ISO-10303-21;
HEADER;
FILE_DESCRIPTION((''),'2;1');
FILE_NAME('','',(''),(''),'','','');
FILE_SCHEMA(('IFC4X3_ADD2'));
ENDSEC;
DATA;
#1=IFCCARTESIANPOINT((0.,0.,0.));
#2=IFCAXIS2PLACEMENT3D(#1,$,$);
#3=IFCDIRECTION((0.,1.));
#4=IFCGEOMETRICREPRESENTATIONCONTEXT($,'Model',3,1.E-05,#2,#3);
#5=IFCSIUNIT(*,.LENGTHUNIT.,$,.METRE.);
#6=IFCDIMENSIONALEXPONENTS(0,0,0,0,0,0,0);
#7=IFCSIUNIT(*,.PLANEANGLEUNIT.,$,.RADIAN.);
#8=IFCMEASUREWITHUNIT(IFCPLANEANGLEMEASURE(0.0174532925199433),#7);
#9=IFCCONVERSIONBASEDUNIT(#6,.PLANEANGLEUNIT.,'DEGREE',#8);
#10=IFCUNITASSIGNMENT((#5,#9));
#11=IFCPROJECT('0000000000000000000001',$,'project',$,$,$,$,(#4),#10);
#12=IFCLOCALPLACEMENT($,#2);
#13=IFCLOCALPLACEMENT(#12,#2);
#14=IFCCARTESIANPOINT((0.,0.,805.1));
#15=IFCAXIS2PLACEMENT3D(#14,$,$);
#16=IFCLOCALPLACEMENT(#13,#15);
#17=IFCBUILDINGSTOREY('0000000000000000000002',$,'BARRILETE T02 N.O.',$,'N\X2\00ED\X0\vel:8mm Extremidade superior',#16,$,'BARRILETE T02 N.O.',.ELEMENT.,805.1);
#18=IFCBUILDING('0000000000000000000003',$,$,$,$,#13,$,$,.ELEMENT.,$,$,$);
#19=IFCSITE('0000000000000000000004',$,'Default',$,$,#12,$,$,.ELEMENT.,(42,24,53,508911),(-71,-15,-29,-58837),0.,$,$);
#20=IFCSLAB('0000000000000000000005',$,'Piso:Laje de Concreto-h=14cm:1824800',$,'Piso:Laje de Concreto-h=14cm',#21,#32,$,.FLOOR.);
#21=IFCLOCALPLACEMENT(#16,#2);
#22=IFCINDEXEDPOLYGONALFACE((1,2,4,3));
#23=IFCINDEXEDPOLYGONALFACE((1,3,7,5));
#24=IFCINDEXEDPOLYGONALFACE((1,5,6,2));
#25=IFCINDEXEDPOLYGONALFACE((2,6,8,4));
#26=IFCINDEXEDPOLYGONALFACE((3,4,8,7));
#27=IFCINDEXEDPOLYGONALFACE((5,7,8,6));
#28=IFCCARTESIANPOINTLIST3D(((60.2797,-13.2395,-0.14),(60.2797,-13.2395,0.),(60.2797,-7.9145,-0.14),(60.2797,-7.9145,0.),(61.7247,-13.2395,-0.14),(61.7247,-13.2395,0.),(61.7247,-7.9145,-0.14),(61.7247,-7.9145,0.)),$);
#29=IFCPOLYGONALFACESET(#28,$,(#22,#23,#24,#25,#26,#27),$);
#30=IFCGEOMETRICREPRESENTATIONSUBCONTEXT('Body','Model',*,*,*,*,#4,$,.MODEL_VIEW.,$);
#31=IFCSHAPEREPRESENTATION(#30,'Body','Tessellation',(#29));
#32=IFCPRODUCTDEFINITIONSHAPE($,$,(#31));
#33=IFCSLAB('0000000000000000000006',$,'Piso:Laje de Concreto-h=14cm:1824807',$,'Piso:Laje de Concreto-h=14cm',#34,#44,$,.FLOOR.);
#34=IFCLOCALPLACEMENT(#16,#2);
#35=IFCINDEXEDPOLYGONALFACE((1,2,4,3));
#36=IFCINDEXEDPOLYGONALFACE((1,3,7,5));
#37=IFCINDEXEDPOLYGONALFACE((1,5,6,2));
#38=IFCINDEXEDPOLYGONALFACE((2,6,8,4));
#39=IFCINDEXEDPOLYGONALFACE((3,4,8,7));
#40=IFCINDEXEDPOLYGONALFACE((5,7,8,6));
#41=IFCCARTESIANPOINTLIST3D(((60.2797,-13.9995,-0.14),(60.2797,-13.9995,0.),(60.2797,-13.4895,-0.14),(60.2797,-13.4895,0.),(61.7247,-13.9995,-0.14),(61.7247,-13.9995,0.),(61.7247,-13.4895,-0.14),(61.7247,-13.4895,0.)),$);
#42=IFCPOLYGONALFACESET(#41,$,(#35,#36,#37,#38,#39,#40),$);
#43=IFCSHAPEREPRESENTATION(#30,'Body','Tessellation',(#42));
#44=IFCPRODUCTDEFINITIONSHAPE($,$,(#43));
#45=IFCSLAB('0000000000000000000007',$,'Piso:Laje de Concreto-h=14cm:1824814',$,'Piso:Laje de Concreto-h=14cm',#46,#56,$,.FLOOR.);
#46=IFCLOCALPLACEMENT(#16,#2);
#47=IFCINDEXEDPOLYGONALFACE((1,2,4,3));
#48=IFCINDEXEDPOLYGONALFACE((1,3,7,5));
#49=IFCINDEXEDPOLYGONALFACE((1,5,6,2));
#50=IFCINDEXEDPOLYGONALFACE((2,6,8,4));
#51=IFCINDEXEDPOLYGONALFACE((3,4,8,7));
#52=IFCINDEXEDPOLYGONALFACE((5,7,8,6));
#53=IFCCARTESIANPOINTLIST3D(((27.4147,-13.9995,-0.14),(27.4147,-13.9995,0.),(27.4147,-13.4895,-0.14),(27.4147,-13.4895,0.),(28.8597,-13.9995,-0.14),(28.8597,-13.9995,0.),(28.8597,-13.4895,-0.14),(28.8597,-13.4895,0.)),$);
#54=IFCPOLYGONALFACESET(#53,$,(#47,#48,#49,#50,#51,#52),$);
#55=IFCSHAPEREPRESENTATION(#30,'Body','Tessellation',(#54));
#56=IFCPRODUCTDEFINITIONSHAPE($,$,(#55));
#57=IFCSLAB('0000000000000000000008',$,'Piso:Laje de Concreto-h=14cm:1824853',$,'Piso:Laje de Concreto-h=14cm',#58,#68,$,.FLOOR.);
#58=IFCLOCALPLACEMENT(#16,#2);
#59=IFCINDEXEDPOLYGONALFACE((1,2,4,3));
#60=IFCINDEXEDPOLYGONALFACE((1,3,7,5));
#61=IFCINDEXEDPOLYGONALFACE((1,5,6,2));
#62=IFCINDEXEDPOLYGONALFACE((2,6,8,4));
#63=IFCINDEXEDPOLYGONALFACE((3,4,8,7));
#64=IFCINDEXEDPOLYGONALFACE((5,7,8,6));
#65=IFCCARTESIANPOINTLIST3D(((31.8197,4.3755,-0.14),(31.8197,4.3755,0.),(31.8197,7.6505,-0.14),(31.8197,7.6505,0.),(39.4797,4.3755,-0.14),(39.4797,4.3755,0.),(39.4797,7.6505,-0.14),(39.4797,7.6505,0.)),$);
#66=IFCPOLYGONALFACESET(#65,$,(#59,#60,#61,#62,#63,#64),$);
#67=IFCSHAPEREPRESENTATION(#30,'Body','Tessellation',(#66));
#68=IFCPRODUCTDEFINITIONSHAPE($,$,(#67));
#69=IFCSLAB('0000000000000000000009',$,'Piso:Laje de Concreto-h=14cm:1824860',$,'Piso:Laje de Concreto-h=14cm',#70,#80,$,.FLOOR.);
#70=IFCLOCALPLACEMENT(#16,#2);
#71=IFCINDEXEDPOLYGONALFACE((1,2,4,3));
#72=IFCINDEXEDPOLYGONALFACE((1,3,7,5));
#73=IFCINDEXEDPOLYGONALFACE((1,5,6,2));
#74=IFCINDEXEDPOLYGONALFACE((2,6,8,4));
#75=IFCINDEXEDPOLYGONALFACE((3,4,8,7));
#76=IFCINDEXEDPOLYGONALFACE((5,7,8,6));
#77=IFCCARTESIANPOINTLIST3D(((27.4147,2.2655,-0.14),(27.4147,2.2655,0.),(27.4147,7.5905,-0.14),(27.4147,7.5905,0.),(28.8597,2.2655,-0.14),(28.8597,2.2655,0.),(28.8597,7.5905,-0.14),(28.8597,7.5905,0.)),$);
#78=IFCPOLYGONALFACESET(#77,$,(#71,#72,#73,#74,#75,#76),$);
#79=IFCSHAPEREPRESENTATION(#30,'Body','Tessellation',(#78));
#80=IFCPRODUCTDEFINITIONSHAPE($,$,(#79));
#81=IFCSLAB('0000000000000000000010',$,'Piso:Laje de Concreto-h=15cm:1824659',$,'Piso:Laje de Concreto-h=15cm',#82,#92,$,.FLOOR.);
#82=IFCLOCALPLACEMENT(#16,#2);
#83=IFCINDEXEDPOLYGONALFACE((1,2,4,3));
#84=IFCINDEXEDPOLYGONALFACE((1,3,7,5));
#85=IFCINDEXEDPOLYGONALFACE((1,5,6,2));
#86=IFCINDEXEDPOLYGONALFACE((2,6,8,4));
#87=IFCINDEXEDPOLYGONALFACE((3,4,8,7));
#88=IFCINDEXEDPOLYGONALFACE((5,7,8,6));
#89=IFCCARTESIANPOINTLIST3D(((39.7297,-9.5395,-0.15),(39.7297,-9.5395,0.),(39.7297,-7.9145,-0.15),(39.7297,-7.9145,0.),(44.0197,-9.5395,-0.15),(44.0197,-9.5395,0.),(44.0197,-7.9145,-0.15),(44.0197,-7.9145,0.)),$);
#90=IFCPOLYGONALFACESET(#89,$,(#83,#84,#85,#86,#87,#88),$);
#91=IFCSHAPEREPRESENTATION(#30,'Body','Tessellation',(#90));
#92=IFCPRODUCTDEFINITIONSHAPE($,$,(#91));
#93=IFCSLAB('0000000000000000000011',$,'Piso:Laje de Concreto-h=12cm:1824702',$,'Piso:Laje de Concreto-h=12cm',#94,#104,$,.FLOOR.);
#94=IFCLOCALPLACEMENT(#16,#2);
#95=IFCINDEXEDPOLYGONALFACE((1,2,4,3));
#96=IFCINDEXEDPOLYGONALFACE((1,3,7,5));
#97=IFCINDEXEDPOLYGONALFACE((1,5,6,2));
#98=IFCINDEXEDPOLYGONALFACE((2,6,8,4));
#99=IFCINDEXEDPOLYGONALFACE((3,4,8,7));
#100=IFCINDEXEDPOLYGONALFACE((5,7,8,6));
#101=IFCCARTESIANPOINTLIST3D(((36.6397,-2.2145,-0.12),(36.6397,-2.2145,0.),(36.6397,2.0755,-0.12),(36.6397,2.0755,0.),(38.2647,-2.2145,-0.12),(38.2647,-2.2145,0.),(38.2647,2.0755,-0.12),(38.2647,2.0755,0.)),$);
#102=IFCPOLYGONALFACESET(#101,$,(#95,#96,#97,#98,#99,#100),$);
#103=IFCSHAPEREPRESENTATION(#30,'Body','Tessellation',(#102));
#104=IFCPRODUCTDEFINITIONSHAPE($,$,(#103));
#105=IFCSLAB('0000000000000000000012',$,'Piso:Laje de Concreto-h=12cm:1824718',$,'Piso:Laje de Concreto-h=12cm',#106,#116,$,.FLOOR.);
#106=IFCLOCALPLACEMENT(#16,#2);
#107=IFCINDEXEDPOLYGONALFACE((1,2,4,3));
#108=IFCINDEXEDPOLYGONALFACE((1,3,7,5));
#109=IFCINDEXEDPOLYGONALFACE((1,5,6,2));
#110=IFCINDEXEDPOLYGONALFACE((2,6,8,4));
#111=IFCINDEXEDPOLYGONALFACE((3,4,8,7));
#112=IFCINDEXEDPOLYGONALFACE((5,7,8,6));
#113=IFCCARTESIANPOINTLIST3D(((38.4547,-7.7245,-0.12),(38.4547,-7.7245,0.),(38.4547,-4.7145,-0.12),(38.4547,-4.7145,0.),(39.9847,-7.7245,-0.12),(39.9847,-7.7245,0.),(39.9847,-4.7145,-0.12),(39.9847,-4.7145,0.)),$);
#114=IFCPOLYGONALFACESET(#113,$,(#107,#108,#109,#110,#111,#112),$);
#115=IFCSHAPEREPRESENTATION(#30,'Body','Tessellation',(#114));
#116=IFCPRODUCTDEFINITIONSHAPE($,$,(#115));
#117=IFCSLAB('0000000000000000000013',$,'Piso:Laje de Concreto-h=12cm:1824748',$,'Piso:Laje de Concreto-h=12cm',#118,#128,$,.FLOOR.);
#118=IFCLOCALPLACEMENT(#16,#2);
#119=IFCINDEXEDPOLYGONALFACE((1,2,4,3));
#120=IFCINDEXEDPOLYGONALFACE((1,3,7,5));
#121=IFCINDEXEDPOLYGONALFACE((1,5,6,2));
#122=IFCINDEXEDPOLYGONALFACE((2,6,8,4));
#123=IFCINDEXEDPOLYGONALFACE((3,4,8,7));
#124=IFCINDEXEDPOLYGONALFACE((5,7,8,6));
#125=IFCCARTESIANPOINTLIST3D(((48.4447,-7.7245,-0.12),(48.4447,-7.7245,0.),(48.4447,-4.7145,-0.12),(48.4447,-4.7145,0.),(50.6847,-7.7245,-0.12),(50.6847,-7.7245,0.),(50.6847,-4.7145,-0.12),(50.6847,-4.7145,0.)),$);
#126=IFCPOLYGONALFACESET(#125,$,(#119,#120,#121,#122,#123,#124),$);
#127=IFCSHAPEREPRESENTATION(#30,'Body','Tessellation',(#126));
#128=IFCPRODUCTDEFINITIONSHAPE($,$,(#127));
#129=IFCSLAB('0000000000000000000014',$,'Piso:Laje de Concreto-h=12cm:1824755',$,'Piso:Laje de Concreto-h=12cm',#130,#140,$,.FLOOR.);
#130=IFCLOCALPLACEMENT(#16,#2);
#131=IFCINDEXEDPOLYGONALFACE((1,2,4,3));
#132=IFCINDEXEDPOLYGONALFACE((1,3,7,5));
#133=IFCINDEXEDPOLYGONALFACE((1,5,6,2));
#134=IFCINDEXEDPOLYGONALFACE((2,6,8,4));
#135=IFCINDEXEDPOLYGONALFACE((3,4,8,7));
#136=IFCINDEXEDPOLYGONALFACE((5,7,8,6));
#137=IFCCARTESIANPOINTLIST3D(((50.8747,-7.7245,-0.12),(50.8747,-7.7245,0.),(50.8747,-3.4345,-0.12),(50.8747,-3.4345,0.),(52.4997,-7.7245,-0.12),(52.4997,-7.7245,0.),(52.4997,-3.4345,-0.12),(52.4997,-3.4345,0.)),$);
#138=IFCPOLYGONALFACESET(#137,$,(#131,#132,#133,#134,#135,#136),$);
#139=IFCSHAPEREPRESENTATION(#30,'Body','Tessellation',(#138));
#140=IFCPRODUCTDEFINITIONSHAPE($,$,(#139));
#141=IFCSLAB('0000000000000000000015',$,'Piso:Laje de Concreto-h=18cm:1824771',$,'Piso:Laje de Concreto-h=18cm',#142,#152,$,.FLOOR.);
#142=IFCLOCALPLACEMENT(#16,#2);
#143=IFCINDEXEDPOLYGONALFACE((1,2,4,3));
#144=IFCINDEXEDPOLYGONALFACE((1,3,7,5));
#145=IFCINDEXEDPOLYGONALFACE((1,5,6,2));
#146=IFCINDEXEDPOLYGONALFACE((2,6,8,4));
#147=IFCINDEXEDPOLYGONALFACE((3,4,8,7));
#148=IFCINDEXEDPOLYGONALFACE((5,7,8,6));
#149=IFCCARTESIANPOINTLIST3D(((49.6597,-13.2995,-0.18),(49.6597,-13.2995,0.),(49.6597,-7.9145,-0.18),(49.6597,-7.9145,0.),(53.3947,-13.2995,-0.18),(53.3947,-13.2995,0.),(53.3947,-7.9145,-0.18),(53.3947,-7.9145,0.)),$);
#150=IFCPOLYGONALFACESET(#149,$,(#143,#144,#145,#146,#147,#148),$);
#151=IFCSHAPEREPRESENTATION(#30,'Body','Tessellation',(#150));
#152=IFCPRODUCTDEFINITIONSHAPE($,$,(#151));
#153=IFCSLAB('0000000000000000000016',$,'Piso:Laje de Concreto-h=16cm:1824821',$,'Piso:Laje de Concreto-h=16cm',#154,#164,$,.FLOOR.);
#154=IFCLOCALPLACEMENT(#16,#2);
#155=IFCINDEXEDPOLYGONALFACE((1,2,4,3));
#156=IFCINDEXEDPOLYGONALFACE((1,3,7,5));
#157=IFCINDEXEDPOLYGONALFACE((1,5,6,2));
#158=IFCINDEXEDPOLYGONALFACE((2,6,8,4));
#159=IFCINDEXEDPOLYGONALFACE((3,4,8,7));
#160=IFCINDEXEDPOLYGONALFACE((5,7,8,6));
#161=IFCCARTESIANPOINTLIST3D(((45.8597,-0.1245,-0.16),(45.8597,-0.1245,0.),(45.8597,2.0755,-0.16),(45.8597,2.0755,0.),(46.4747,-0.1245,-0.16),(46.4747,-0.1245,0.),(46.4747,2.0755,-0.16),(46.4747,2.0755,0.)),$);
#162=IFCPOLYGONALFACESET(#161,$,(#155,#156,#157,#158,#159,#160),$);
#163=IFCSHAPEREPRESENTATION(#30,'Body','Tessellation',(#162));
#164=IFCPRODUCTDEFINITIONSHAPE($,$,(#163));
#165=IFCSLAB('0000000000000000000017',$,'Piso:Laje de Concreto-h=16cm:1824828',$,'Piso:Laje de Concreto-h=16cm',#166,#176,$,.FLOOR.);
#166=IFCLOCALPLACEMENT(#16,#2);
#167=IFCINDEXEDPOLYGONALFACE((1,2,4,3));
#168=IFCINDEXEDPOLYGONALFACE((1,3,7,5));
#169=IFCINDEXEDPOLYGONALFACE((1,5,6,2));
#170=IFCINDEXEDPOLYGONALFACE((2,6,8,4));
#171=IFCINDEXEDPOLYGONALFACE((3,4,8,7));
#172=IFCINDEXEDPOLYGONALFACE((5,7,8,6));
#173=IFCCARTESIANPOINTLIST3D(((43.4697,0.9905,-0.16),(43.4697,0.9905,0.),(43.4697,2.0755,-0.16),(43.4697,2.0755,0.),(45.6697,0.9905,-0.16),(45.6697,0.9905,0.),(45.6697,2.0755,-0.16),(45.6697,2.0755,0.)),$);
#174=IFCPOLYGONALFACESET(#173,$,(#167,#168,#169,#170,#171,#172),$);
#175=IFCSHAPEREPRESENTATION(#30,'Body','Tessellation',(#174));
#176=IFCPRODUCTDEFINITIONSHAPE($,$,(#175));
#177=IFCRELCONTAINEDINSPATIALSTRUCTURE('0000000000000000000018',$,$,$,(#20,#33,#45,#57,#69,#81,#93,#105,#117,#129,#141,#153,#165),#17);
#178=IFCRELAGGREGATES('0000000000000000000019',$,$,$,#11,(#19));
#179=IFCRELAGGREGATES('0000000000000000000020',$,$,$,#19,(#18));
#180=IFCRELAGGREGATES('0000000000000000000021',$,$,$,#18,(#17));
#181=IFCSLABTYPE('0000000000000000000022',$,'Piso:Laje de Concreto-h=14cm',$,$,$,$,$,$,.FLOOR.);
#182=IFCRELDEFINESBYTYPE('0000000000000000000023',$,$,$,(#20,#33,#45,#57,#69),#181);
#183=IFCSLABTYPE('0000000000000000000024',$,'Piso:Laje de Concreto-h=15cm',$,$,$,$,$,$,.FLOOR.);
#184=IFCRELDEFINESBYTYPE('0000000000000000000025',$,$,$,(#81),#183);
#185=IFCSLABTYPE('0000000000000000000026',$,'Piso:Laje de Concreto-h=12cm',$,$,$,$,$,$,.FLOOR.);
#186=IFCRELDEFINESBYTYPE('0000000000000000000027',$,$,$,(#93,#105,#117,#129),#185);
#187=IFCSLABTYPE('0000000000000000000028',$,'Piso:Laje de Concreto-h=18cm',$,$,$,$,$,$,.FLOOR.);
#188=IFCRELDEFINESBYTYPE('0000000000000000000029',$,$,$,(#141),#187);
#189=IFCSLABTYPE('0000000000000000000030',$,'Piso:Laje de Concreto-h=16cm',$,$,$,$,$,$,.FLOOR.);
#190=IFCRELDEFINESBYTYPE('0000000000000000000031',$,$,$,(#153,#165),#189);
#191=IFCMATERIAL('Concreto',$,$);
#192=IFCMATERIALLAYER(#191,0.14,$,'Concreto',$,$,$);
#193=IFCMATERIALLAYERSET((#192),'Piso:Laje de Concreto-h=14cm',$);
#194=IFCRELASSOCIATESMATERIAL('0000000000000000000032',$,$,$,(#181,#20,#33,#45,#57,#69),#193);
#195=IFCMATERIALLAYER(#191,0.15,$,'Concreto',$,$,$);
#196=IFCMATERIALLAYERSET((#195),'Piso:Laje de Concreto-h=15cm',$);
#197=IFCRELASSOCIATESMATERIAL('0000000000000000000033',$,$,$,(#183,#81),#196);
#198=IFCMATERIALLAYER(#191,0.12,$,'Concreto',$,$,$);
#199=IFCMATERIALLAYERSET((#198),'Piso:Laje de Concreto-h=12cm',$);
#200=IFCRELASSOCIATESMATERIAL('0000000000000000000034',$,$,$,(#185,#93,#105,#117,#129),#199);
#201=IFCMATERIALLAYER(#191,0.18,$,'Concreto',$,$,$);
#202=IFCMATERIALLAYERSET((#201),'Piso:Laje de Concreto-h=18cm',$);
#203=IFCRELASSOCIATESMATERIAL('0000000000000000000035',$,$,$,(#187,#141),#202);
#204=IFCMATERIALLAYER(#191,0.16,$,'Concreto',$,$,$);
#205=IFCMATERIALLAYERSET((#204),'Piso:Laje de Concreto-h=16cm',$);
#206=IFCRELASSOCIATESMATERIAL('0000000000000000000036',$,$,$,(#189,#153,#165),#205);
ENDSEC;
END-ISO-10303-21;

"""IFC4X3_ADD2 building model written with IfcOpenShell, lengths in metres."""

from ifc_helpers import new_model, entity, si_unit, converted_unit, direction, frame, frame_2d, origin, origin_2d_with_axis, place, context, subcontext, project, spatial, rectangle, extrude, material, layer, layer_set, layer_usage, type_object, element, save


model = new_model("IFC4X3_ADD2")

# Units and contexts
model_context = context("Model", 3, precision=1e-05, world=origin(), true_north=direction((0.0, 1.0)))
body_context = subcontext(model_context, "Body", "Model", "MODEL_VIEW")
ifc_project = project(units=[si_unit("LENGTHUNIT", "METRE"), converted_unit("PLANEANGLEUNIT", "DEGREE", entity("IfcPlaneAngleMeasure", 0.0174532925199433), si_unit("PLANEANGLEUNIT", "RADIAN"), dimensions=[0, 0, 0, 0, 0, 0, 0])], contexts=[model_context])

# Site, building, storey
site_placement = place(None, origin())
site = spatial("IfcSite", under=ifc_project, at=site_placement, Name="Default", CompositionType="ELEMENT", RefLatitude=(42, 24, 53, 508911), RefLongitude=(-71, -15, -29, -58837), RefElevation=0.0)
building_placement = place(site_placement, origin())
building = spatial("IfcBuilding", under=site, at=building_placement, CompositionType="ELEMENT")
storey_placement = place(building_placement, frame((0.0, 0.0, 805.1)))
storey = spatial("IfcBuildingStorey", under=building, at=storey_placement, Name="BARRILETE T02 N.O.", ObjectType="Nível:8mm Extremidade superior", LongName="BARRILETE T02 N.O.", CompositionType="ELEMENT", Elevation=805.1)

# Shared definitions
ifc_material = material(Name="Concreto")
ifc_layer_1 = layer(ifc_material, 0.14, Name="Concreto")
ifc_layer_set_1 = layer_set([ifc_layer_1], Name="Piso:Laje de Concreto-h=14cm")
slab_type_1 = type_object("IfcSlabType", Name="Piso:Laje de Concreto-h=14cm", PredefinedType="FLOOR", material=ifc_layer_set_1)

# Slabs
ifc_layer_usage_1 = layer_usage(ifc_layer_set_1, "AXIS3", "POSITIVE", 0.0)
slab_1_placement = place(storey_placement, origin())
element("IfcSlab", 1, at=slab_1_placement, inside=storey, type_object=slab_type_1, material=ifc_layer_usage_1, Name="Piso:Laje de Concreto-h=14cm:1824800", ObjectType="Piso:Laje de Concreto-h=14cm", PredefinedType="FLOOR", context=body_context, shape_type="SweptSolid", body=[
    extrude(rectangle(XDim=5.325, YDim=1.445, at=frame_2d((0.0, 0.0), x_axis=(1.0, 0.0))), frame((61.0022, -10.577, 0.0), z_axis=(0.0, 0.0, -1.0), x_axis=(0.0, 1.0, 0.0)), (0.0, 0.0, 1.0), 0.14),
])
ifc_layer_usage_2 = layer_usage(ifc_layer_set_1, "AXIS3", "POSITIVE", 0.0)
slab_2_placement = place(storey_placement, origin())
element("IfcSlab", 2, at=slab_2_placement, inside=storey, type_object=slab_type_1, material=ifc_layer_usage_2, Name="Piso:Laje de Concreto-h=14cm:1824807", ObjectType="Piso:Laje de Concreto-h=14cm", PredefinedType="FLOOR", context=body_context, shape_type="SweptSolid", body=[
    extrude(rectangle(XDim=0.51, YDim=1.445, at=frame_2d((0.0, 0.0), x_axis=(1.0, 0.0))), frame((61.0022, -13.7445, 0.0), z_axis=(0.0, 0.0, -1.0), x_axis=(0.0, 1.0, 0.0)), (0.0, 0.0, 1.0), 0.14),
])
ifc_layer_usage_3 = layer_usage(ifc_layer_set_1, "AXIS3", "POSITIVE", 0.0)
slab_3_placement = place(storey_placement, origin())
element("IfcSlab", 3, at=slab_3_placement, inside=storey, type_object=slab_type_1, material=ifc_layer_usage_3, Name="Piso:Laje de Concreto-h=14cm:1824814", ObjectType="Piso:Laje de Concreto-h=14cm", PredefinedType="FLOOR", context=body_context, shape_type="SweptSolid", body=[
    extrude(rectangle(XDim=0.51, YDim=1.445, at=origin_2d_with_axis()), frame((28.1372, -13.7445, 0.0), z_axis=(0.0, 0.0, -1.0), x_axis=(0.0, 1.0, 0.0)), (0.0, 0.0, 1.0), 0.14),
])
ifc_layer_usage_4 = layer_usage(ifc_layer_set_1, "AXIS3", "POSITIVE", 0.0)
slab_4_placement = place(storey_placement, origin())
element("IfcSlab", 4, at=slab_4_placement, inside=storey, type_object=slab_type_1, material=ifc_layer_usage_4, Name="Piso:Laje de Concreto-h=14cm:1824853", ObjectType="Piso:Laje de Concreto-h=14cm", PredefinedType="FLOOR", context=body_context, shape_type="SweptSolid", body=[
    extrude(rectangle(XDim=3.275, YDim=7.66, at=origin_2d_with_axis()), frame((35.6497, 6.013, 0.0), z_axis=(0.0, 0.0, -1.0), x_axis=(0.0, 1.0, 0.0)), (0.0, 0.0, 1.0), 0.14),
])
ifc_layer_usage_5 = layer_usage(ifc_layer_set_1, "AXIS3", "POSITIVE", 0.0)
slab_5_placement = place(storey_placement, origin())
element("IfcSlab", 5, at=slab_5_placement, inside=storey, type_object=slab_type_1, material=ifc_layer_usage_5, Name="Piso:Laje de Concreto-h=14cm:1824860", ObjectType="Piso:Laje de Concreto-h=14cm", PredefinedType="FLOOR", context=body_context, shape_type="SweptSolid", body=[
    extrude(rectangle(XDim=5.325, YDim=1.445, at=origin_2d_with_axis()), frame((28.1372, 4.928, 0.0), z_axis=(0.0, 0.0, -1.0), x_axis=(0.0, 1.0, 0.0)), (0.0, 0.0, 1.0), 0.14),
])
ifc_layer_2 = layer(ifc_material, 0.15, Name="Concreto")
ifc_layer_set_2 = layer_set([ifc_layer_2], Name="Piso:Laje de Concreto-h=15cm")
ifc_layer_usage_6 = layer_usage(ifc_layer_set_2, "AXIS3", "POSITIVE", 0.0)
slab_type_2 = type_object("IfcSlabType", Name="Piso:Laje de Concreto-h=15cm", PredefinedType="FLOOR", material=ifc_layer_set_2)
slab_6_placement = place(storey_placement, origin())
element("IfcSlab", 6, at=slab_6_placement, inside=storey, type_object=slab_type_2, material=ifc_layer_usage_6, Name="Piso:Laje de Concreto-h=15cm:1824659", ObjectType="Piso:Laje de Concreto-h=15cm", PredefinedType="FLOOR", context=body_context, shape_type="SweptSolid", body=[
    extrude(rectangle(XDim=1.625, YDim=4.29, at=frame_2d((0.0, 0.0), x_axis=(1.0, 0.0))), frame((41.8747, -8.727, 0.0), z_axis=(0.0, 0.0, -1.0), x_axis=(0.0, 1.0, 0.0)), (0.0, 0.0, 1.0), 0.15),
])
ifc_layer_3 = layer(ifc_material, 0.12, Name="Concreto")
ifc_layer_set_3 = layer_set([ifc_layer_3], Name="Piso:Laje de Concreto-h=12cm")
slab_type_3 = type_object("IfcSlabType", Name="Piso:Laje de Concreto-h=12cm", PredefinedType="FLOOR", material=ifc_layer_set_3)
ifc_layer_usage_7 = layer_usage(ifc_layer_set_3, "AXIS3", "POSITIVE", 0.0)
slab_7_placement = place(storey_placement, origin())
element("IfcSlab", 7, at=slab_7_placement, inside=storey, type_object=slab_type_3, material=ifc_layer_usage_7, Name="Piso:Laje de Concreto-h=12cm:1824702", ObjectType="Piso:Laje de Concreto-h=12cm", PredefinedType="FLOOR", context=body_context, shape_type="SweptSolid", body=[
    extrude(rectangle(XDim=4.29, YDim=1.625, at=origin_2d_with_axis()), frame((37.4522, -0.0695, 0.0), z_axis=(0.0, 0.0, -1.0), x_axis=(0.0, 1.0, 0.0)), (0.0, 0.0, 1.0), 0.12),
])
ifc_layer_usage_8 = layer_usage(ifc_layer_set_3, "AXIS3", "POSITIVE", 0.0)
slab_8_placement = place(storey_placement, origin())
element("IfcSlab", 8, at=slab_8_placement, inside=storey, type_object=slab_type_3, material=ifc_layer_usage_8, Name="Piso:Laje de Concreto-h=12cm:1824718", ObjectType="Piso:Laje de Concreto-h=12cm", PredefinedType="FLOOR", context=body_context, shape_type="SweptSolid", body=[
    extrude(rectangle(XDim=3.01, YDim=1.53, at=frame_2d((0.0, 0.0), x_axis=(1.0, 0.0))), frame((39.2197, -6.2195, 0.0), z_axis=(0.0, 0.0, -1.0), x_axis=(0.0, 1.0, 0.0)), (0.0, 0.0, 1.0), 0.12),
])
ifc_layer_usage_9 = layer_usage(ifc_layer_set_3, "AXIS3", "POSITIVE", 0.0)
slab_9_placement = place(storey_placement, origin())
element("IfcSlab", 9, at=slab_9_placement, inside=storey, type_object=slab_type_3, material=ifc_layer_usage_9, Name="Piso:Laje de Concreto-h=12cm:1824748", ObjectType="Piso:Laje de Concreto-h=12cm", PredefinedType="FLOOR", context=body_context, shape_type="SweptSolid", body=[
    extrude(rectangle(XDim=3.01, YDim=2.24, at=frame_2d((0.0, 0.0), x_axis=(1.0, 0.0))), frame((49.5647, -6.2195, 0.0), z_axis=(0.0, 0.0, -1.0), x_axis=(0.0, 1.0, 0.0)), (0.0, 0.0, 1.0), 0.12),
])
ifc_layer_usage_10 = layer_usage(ifc_layer_set_3, "AXIS3", "POSITIVE", 0.0)
slab_10_placement = place(storey_placement, origin())
element("IfcSlab", 10, at=slab_10_placement, inside=storey, type_object=slab_type_3, material=ifc_layer_usage_10, Name="Piso:Laje de Concreto-h=12cm:1824755", ObjectType="Piso:Laje de Concreto-h=12cm", PredefinedType="FLOOR", context=body_context, shape_type="SweptSolid", body=[
    extrude(rectangle(XDim=4.29, YDim=1.625, at=origin_2d_with_axis()), frame((51.6872, -5.5795, 0.0), z_axis=(0.0, 0.0, -1.0), x_axis=(0.0, 1.0, 0.0)), (0.0, 0.0, 1.0), 0.12),
])
ifc_layer_4 = layer(ifc_material, 0.18, Name="Concreto")
ifc_layer_set_4 = layer_set([ifc_layer_4], Name="Piso:Laje de Concreto-h=18cm")
slab_type_4 = type_object("IfcSlabType", Name="Piso:Laje de Concreto-h=18cm", PredefinedType="FLOOR", material=ifc_layer_set_4)
ifc_layer_usage_11 = layer_usage(ifc_layer_set_4, "AXIS3", "POSITIVE", 0.0)
slab_11_placement = place(storey_placement, origin())
element("IfcSlab", 11, at=slab_11_placement, inside=storey, type_object=slab_type_4, material=ifc_layer_usage_11, Name="Piso:Laje de Concreto-h=18cm:1824771", ObjectType="Piso:Laje de Concreto-h=18cm", PredefinedType="FLOOR", context=body_context, shape_type="SweptSolid", body=[
    extrude(rectangle(XDim=5.385, YDim=3.735, at=frame_2d((0.0, 0.0), x_axis=(1.0, 0.0))), frame((51.5272, -10.607, 0.0), z_axis=(0.0, 0.0, -1.0), x_axis=(0.0, 1.0, 0.0)), (0.0, 0.0, 1.0), 0.18),
])
ifc_layer_5 = layer(ifc_material, 0.16, Name="Concreto")
ifc_layer_set_5 = layer_set([ifc_layer_5], Name="Piso:Laje de Concreto-h=16cm")
ifc_layer_usage_12 = layer_usage(ifc_layer_set_5, "AXIS3", "POSITIVE", 0.0)
slab_type_5 = type_object("IfcSlabType", Name="Piso:Laje de Concreto-h=16cm", PredefinedType="FLOOR", material=ifc_layer_set_5)
slab_12_placement = place(storey_placement, origin())
element("IfcSlab", 12, at=slab_12_placement, inside=storey, type_object=slab_type_5, material=ifc_layer_usage_12, Name="Piso:Laje de Concreto-h=16cm:1824821", ObjectType="Piso:Laje de Concreto-h=16cm", PredefinedType="FLOOR", context=body_context, shape_type="SweptSolid", body=[
    extrude(rectangle(XDim=2.2, YDim=0.615, at=origin_2d_with_axis()), frame((46.1672, 0.9755, 0.0), z_axis=(0.0, 0.0, -1.0), x_axis=(0.0, 1.0, 0.0)), (0.0, 0.0, 1.0), 0.16),
])
ifc_layer_usage_13 = layer_usage(ifc_layer_set_5, "AXIS3", "POSITIVE", 0.0)
slab_13_placement = place(storey_placement, origin())
element("IfcSlab", 13, at=slab_13_placement, inside=storey, type_object=slab_type_5, material=ifc_layer_usage_13, Name="Piso:Laje de Concreto-h=16cm:1824828", ObjectType="Piso:Laje de Concreto-h=16cm", PredefinedType="FLOOR", context=body_context, shape_type="SweptSolid", body=[
    extrude(rectangle(XDim=1.085, YDim=2.2, at=origin_2d_with_axis()), frame((44.5697, 1.533, 0.0), z_axis=(0.0, 0.0, -1.0), x_axis=(0.0, 1.0, 0.0)), (0.0, 0.0, 1.0), 0.16),
])

save(model, "model.ifc")
